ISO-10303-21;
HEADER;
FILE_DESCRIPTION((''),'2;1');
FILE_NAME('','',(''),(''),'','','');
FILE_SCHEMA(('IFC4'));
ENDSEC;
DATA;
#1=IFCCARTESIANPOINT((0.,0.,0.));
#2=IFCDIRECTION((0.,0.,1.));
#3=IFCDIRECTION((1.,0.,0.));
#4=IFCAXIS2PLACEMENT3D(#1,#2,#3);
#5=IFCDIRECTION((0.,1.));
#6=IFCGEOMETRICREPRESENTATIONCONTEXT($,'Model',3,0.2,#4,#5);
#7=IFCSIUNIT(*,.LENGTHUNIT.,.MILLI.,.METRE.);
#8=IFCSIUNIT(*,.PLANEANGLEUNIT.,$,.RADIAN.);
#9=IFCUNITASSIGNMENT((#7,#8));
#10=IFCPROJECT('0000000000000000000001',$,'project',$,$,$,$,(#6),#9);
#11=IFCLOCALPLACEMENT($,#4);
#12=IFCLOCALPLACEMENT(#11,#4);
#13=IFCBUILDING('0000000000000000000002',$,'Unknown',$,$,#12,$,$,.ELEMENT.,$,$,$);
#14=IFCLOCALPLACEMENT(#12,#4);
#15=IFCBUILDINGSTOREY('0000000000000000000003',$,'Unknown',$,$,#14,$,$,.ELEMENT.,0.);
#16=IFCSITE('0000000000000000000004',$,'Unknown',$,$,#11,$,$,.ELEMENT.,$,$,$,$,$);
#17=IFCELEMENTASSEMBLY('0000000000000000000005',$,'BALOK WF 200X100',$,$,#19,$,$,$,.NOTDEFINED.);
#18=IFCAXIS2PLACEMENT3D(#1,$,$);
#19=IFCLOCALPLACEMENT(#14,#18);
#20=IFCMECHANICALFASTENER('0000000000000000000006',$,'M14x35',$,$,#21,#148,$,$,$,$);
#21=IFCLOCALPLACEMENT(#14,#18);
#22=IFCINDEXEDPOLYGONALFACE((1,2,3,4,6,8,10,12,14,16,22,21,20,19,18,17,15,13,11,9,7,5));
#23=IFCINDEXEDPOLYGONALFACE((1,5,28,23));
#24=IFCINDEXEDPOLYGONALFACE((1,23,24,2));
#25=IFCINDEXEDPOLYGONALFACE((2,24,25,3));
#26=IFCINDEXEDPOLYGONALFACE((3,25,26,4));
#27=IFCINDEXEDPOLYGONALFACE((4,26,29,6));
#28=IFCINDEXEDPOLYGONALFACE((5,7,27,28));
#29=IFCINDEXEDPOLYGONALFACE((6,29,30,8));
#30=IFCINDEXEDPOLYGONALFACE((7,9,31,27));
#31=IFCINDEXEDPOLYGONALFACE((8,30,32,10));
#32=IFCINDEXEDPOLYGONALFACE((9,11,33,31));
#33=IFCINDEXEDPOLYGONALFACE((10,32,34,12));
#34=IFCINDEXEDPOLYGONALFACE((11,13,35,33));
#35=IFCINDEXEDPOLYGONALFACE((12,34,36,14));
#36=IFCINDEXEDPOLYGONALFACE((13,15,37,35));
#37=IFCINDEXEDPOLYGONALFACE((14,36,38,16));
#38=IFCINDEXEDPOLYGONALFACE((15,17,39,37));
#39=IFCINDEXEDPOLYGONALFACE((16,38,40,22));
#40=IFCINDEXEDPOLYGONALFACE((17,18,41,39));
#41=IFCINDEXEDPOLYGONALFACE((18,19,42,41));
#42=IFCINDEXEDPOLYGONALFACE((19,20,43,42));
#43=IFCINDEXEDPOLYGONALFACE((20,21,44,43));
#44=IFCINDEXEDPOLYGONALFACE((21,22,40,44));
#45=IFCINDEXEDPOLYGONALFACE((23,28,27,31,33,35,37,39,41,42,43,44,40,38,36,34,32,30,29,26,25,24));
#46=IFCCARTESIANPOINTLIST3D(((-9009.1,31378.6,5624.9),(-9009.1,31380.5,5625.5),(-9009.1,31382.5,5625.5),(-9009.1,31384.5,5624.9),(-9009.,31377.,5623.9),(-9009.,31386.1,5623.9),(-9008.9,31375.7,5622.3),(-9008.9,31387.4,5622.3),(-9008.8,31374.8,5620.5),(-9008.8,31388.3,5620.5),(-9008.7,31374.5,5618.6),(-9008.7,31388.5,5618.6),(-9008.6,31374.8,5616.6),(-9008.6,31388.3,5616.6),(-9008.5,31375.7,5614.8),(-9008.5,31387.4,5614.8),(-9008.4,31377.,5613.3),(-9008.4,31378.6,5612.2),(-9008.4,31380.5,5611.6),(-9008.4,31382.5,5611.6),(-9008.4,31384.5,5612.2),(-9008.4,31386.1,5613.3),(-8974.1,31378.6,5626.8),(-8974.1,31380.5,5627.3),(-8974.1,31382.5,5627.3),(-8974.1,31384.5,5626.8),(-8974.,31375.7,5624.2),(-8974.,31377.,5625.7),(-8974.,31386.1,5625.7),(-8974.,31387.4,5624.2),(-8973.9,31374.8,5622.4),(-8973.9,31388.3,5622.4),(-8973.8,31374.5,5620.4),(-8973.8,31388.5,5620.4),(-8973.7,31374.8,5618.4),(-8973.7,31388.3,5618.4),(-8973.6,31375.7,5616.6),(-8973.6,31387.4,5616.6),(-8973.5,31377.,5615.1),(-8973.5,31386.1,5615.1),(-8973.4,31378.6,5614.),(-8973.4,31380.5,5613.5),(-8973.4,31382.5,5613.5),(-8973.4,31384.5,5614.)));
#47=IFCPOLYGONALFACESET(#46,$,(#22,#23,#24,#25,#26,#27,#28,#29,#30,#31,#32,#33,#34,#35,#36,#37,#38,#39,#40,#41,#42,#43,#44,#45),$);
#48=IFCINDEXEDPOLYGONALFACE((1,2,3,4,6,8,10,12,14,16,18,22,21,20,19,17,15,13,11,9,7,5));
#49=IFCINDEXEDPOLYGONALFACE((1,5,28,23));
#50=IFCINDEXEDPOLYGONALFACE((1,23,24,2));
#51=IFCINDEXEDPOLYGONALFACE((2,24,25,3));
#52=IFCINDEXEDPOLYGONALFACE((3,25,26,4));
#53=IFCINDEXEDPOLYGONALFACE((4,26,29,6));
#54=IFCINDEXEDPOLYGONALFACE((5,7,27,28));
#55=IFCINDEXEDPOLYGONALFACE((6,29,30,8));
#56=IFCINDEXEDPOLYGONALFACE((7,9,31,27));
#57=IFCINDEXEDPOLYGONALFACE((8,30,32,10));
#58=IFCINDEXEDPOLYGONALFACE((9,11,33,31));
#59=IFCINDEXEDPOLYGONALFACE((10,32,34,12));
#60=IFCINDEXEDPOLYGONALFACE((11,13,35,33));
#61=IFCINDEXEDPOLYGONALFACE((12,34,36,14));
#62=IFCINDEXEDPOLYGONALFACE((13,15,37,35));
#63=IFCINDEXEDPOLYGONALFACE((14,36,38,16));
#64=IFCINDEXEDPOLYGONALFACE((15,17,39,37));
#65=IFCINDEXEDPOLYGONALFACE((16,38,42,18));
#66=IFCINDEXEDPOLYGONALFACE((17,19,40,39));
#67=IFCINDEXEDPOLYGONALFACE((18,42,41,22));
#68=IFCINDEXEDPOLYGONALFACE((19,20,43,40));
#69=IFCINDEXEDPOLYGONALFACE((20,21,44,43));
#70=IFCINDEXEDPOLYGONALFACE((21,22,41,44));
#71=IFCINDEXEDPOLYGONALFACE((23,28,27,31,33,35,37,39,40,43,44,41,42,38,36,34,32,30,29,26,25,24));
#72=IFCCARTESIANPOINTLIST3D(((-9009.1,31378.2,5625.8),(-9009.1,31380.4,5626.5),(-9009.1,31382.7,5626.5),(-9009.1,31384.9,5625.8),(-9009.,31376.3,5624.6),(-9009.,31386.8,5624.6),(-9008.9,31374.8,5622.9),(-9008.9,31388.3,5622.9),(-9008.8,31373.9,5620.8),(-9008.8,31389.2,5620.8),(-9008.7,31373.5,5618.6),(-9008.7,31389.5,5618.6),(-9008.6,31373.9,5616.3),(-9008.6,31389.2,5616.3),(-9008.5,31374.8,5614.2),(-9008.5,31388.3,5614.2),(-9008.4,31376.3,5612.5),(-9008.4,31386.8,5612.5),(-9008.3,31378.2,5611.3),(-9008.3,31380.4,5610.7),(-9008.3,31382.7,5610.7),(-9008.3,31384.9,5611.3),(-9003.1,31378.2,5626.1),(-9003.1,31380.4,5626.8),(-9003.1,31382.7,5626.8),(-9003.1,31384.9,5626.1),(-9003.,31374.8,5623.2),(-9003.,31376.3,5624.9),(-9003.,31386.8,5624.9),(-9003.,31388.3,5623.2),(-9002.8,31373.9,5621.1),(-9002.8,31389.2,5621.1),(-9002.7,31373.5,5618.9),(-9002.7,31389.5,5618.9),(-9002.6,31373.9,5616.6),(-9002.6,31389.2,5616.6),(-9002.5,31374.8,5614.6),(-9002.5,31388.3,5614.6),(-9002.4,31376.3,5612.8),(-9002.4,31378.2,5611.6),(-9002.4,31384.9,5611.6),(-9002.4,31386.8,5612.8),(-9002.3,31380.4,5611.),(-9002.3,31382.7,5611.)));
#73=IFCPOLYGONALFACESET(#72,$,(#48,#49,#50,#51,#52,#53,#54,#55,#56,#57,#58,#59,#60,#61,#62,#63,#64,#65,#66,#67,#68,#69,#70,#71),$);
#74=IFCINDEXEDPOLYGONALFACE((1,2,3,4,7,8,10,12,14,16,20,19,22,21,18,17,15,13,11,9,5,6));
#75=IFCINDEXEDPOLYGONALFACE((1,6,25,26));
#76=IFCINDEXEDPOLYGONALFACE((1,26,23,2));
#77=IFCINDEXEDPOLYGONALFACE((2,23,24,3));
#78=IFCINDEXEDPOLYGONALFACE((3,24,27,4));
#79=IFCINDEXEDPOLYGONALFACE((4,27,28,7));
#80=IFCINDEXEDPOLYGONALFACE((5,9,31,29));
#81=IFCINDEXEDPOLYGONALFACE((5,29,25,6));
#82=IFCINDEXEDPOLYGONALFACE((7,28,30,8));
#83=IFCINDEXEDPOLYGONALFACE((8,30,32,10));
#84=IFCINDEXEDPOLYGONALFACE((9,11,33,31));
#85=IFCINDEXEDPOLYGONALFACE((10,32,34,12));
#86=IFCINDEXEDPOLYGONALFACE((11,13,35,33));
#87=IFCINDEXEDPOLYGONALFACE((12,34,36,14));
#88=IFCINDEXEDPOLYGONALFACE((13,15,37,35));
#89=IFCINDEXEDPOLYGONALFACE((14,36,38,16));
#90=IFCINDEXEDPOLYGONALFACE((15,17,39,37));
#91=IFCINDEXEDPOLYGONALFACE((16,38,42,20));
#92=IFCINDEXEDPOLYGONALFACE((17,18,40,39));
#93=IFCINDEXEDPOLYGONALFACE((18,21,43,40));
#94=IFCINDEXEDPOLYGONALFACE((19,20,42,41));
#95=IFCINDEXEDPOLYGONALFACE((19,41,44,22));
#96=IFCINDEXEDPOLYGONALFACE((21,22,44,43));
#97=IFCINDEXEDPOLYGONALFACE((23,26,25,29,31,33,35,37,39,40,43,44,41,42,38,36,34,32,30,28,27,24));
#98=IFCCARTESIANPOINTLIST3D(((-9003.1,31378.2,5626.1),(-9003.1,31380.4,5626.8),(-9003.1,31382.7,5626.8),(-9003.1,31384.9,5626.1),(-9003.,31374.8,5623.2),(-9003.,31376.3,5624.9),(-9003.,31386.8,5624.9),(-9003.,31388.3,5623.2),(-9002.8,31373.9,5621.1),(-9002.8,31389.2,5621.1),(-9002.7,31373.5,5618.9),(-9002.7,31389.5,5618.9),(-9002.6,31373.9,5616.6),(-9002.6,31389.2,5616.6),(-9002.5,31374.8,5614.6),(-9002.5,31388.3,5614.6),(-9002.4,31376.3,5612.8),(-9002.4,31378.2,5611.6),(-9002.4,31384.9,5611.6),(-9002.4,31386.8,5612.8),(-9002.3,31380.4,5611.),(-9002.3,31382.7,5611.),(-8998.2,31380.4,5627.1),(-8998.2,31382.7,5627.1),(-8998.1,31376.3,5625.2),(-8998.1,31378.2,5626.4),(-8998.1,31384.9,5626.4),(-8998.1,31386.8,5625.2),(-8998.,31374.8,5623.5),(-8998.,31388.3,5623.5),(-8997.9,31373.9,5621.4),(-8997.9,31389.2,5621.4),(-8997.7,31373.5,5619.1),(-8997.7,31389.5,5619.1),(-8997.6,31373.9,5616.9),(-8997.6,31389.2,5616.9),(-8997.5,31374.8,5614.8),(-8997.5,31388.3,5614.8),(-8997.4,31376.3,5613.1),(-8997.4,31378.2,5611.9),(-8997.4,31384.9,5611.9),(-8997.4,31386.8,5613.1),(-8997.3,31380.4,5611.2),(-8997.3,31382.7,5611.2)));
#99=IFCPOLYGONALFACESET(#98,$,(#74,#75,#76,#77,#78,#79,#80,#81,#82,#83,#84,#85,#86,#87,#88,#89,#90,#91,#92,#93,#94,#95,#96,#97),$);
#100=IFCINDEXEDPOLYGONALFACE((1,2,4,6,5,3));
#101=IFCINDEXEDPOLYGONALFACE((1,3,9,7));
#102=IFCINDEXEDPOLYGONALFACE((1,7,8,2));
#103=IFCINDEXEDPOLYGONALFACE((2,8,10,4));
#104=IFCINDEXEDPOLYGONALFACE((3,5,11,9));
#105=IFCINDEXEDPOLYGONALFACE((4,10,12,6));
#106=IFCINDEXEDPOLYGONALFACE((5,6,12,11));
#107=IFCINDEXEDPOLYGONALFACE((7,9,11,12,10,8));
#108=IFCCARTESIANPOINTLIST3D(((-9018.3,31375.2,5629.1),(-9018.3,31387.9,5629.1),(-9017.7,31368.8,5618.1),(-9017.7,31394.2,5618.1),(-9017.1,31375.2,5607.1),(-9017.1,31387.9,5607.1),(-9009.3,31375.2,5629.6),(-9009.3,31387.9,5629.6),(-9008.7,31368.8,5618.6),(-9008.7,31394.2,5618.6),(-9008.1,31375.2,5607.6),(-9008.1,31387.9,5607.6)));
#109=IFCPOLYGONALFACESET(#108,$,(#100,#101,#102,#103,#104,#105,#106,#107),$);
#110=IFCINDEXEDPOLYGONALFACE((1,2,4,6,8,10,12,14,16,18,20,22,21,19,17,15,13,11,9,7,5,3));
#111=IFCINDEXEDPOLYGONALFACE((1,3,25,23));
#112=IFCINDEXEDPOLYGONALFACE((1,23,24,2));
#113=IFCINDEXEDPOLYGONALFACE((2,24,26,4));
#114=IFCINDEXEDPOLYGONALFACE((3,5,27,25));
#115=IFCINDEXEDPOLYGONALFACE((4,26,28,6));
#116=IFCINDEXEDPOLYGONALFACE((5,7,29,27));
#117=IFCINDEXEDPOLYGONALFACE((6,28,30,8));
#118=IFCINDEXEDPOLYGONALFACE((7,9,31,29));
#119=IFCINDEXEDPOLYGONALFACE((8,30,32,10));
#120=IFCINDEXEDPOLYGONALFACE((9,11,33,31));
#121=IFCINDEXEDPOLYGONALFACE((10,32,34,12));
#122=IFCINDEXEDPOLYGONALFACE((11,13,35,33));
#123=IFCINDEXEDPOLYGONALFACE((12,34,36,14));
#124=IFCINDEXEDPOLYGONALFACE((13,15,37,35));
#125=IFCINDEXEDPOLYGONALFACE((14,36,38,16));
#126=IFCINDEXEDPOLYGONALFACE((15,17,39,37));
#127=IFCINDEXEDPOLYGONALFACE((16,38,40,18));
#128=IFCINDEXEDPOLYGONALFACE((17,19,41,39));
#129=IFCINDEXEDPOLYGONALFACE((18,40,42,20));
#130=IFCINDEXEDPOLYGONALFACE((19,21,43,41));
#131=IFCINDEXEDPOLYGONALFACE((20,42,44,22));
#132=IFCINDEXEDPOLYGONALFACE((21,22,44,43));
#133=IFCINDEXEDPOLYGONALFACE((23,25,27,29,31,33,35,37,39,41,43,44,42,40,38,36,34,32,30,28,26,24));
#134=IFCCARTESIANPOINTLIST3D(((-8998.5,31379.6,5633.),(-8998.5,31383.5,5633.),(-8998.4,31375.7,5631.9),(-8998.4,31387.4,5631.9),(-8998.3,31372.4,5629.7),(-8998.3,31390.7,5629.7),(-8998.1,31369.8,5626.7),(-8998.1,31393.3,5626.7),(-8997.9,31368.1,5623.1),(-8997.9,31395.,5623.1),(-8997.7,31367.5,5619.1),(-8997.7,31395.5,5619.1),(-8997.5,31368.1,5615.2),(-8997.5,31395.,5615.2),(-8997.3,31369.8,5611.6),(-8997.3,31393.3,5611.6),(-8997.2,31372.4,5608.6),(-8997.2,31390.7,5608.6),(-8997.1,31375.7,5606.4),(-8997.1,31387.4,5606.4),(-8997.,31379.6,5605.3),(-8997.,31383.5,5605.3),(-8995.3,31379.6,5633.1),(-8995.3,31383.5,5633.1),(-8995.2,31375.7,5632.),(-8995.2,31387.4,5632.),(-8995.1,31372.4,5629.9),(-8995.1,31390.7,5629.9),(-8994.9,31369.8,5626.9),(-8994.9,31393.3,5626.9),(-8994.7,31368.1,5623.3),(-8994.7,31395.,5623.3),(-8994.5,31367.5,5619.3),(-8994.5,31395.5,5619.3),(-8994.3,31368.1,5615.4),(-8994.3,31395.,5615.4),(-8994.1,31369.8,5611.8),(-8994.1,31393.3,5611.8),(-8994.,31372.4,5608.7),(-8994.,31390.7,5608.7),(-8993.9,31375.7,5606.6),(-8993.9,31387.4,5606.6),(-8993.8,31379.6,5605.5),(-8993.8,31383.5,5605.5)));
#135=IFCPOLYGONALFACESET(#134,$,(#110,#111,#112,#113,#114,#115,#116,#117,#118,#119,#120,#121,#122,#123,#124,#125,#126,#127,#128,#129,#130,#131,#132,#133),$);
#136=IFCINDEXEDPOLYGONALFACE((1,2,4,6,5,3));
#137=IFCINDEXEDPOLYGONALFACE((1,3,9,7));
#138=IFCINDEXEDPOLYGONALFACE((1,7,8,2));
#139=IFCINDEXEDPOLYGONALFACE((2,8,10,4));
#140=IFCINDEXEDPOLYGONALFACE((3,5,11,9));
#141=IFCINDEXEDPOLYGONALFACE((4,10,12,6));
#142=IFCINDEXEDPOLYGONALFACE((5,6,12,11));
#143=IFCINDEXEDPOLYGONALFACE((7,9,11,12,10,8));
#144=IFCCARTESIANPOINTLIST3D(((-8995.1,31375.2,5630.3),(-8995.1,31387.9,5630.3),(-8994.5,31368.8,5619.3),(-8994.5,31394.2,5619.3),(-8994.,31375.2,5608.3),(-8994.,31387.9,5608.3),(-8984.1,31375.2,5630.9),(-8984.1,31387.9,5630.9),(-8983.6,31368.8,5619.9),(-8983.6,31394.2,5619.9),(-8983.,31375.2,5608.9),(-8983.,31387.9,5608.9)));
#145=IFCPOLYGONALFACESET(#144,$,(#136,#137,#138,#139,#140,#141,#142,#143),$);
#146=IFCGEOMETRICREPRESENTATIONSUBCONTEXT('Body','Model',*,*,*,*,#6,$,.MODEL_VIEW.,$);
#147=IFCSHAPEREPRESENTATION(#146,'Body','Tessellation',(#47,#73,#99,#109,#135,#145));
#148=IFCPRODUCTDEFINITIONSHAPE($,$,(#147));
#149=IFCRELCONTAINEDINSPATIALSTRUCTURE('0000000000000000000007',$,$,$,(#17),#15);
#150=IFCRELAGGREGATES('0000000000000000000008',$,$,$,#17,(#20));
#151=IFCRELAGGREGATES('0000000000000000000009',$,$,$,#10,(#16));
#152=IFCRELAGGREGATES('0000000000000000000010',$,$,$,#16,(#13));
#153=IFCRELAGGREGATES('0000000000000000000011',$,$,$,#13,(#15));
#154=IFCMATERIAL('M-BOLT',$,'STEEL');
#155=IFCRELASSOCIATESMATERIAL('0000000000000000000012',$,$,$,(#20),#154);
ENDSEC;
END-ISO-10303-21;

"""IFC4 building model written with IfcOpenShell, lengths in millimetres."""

from ifc_helpers import new_model, si_unit, direction, frame, origin_with_axes, place, context, subcontext, project, spatial, line, arc, indexed_curve, outline, extrude, source, transform, mapped, material, element, aggregate, save


model = new_model("IFC4")

# Units and contexts
model_context = context("Model", 3, precision=0.2, world=origin_with_axes(), true_north=direction((0.0, 1.0)))
body_context = subcontext(model_context, "Body", "Model", "MODEL_VIEW")
ifc_project = project(units=[si_unit("LENGTHUNIT", "METRE", prefix="MILLI"), si_unit("PLANEANGLEUNIT", "RADIAN")], contexts=[model_context])

# Site, building, storey
site_placement = place(None, origin_with_axes())
site = spatial("IfcSite", under=ifc_project, at=site_placement, Name="Unknown", CompositionType="ELEMENT")
building_placement = place(site_placement, origin_with_axes())
building = spatial("IfcBuilding", under=site, at=building_placement, Name="Unknown", CompositionType="ELEMENT")
storey_placement = place(building_placement, origin_with_axes())
storey = spatial("IfcBuildingStorey", under=building, at=storey_placement, Name="Unknown", CompositionType="ELEMENT", Elevation=0.0)

# Element assembly
assembly_1_placement = place(storey_placement, frame((-7044.1, 31466.5, 5721.5), z_axis=(0.0, 1.0, 0.0), x_axis=(-0.99863, 0.0, -0.052336)))
assembly_1 = element("IfcElementAssembly", 1, at=assembly_1_placement, inside=storey, Name="BALOK WF 200X100", PredefinedType="NOTDEFINED")

# Shared definitions
ifc_material_1 = material(Name="M-BOLT", Category="STEEL")

# Mechanical fastener
shared_shape_1 = source(origin_with_axes(), body_context, "Body", "SweptSolid", [
    extrude(outline(indexed_curve([(7.0, 0.0), (0.0, 7.0), (-7.0, 0.0), (0.0, -7.0)], segments=[arc(1, 2, 3), arc(3, 4, 1)])), frame((0.0, 0.0, -2.6), z_axis=(0.0, 0.0, -1.0), x_axis=(0.0, 1.0, 0.0)), (0.0, 0.0, 1.0), 35.0),
    extrude(outline(indexed_curve([(8.0, 0.0), (0.0, 8.0), (-8.0, 0.0), (0.0, -8.0)], segments=[arc(1, 2, 3), arc(3, 4, 1)])), frame((0.0, 0.0, -2.6), z_axis=(0.0, 0.0, -1.0), x_axis=(0.0, 1.0, 0.0)), (0.0, 0.0, 1.0), 6.0),
    extrude(outline(indexed_curve([(8.0, 0.0), (0.0, 8.0), (-8.0, 0.0), (0.0, -8.0)], segments=[arc(1, 2, 3), arc(3, 4, 1)])), frame((0.0, 0.0, -8.6), z_axis=(0.0, 0.0, -1.0), x_axis=(0.0, 1.0, 0.0)), (0.0, 0.0, 1.0), 5.0),
    extrude(outline(indexed_curve([(12.7, 0.0), (6.4, 11.0), (-6.4, 11.0), (-12.7, 0.0), (-6.4, -11.0), (6.4, -11.0)], segments=[line(1, 2, 3, 4, 5, 6, 1)])), frame((0.0, 0.0, 6.4), z_axis=(0.0, 0.0, -1.0), x_axis=(0.0, 1.0, 0.0)), (0.0, 0.0, 1.0), 9.0),
    extrude(outline(indexed_curve([(14.0, 0.0), (0.0, 14.0), (-14.0, 0.0), (0.0, -14.0)], segments=[arc(1, 2, 3), arc(3, 4, 1)])), frame((0.0, 0.0, -13.6), z_axis=(0.0, 0.0, -1.0), x_axis=(0.0, 1.0, 0.0)), (0.0, 0.0, 1.0), 3.2),
    extrude(outline(indexed_curve([(12.7, 0.0), (6.4, 11.0), (-6.4, 11.0), (-12.7, 0.0), (-6.4, -11.0), (6.4, -11.0)], segments=[line(1, 2, 3, 4, 5, 6, 1)])), frame((0.0, 0.0, -16.8), z_axis=(0.0, 0.0, -1.0), x_axis=(0.0, 1.0, 0.0)), (0.0, 0.0, 1.0), 11.0),
])
mechanical_fastener_1_placement = place(assembly_1_placement, frame((1969.9, 0.1, -85.0), z_axis=(1.0, 0.0, -0.000006), x_axis=(0.0, -1.0, 0.0)))
mechanical_fastener_1 = element("IfcMechanicalFastener", 2, at=mechanical_fastener_1_placement, material=ifc_material_1, Name="M14x35", context=body_context, shape_type="MappedRepresentation", body=[
    mapped(shared_shape_1, transform((0.0, 0.0, 0.0))),
])
aggregate(assembly_1, [mechanical_fastener_1])

save(model, "model.ifc")
